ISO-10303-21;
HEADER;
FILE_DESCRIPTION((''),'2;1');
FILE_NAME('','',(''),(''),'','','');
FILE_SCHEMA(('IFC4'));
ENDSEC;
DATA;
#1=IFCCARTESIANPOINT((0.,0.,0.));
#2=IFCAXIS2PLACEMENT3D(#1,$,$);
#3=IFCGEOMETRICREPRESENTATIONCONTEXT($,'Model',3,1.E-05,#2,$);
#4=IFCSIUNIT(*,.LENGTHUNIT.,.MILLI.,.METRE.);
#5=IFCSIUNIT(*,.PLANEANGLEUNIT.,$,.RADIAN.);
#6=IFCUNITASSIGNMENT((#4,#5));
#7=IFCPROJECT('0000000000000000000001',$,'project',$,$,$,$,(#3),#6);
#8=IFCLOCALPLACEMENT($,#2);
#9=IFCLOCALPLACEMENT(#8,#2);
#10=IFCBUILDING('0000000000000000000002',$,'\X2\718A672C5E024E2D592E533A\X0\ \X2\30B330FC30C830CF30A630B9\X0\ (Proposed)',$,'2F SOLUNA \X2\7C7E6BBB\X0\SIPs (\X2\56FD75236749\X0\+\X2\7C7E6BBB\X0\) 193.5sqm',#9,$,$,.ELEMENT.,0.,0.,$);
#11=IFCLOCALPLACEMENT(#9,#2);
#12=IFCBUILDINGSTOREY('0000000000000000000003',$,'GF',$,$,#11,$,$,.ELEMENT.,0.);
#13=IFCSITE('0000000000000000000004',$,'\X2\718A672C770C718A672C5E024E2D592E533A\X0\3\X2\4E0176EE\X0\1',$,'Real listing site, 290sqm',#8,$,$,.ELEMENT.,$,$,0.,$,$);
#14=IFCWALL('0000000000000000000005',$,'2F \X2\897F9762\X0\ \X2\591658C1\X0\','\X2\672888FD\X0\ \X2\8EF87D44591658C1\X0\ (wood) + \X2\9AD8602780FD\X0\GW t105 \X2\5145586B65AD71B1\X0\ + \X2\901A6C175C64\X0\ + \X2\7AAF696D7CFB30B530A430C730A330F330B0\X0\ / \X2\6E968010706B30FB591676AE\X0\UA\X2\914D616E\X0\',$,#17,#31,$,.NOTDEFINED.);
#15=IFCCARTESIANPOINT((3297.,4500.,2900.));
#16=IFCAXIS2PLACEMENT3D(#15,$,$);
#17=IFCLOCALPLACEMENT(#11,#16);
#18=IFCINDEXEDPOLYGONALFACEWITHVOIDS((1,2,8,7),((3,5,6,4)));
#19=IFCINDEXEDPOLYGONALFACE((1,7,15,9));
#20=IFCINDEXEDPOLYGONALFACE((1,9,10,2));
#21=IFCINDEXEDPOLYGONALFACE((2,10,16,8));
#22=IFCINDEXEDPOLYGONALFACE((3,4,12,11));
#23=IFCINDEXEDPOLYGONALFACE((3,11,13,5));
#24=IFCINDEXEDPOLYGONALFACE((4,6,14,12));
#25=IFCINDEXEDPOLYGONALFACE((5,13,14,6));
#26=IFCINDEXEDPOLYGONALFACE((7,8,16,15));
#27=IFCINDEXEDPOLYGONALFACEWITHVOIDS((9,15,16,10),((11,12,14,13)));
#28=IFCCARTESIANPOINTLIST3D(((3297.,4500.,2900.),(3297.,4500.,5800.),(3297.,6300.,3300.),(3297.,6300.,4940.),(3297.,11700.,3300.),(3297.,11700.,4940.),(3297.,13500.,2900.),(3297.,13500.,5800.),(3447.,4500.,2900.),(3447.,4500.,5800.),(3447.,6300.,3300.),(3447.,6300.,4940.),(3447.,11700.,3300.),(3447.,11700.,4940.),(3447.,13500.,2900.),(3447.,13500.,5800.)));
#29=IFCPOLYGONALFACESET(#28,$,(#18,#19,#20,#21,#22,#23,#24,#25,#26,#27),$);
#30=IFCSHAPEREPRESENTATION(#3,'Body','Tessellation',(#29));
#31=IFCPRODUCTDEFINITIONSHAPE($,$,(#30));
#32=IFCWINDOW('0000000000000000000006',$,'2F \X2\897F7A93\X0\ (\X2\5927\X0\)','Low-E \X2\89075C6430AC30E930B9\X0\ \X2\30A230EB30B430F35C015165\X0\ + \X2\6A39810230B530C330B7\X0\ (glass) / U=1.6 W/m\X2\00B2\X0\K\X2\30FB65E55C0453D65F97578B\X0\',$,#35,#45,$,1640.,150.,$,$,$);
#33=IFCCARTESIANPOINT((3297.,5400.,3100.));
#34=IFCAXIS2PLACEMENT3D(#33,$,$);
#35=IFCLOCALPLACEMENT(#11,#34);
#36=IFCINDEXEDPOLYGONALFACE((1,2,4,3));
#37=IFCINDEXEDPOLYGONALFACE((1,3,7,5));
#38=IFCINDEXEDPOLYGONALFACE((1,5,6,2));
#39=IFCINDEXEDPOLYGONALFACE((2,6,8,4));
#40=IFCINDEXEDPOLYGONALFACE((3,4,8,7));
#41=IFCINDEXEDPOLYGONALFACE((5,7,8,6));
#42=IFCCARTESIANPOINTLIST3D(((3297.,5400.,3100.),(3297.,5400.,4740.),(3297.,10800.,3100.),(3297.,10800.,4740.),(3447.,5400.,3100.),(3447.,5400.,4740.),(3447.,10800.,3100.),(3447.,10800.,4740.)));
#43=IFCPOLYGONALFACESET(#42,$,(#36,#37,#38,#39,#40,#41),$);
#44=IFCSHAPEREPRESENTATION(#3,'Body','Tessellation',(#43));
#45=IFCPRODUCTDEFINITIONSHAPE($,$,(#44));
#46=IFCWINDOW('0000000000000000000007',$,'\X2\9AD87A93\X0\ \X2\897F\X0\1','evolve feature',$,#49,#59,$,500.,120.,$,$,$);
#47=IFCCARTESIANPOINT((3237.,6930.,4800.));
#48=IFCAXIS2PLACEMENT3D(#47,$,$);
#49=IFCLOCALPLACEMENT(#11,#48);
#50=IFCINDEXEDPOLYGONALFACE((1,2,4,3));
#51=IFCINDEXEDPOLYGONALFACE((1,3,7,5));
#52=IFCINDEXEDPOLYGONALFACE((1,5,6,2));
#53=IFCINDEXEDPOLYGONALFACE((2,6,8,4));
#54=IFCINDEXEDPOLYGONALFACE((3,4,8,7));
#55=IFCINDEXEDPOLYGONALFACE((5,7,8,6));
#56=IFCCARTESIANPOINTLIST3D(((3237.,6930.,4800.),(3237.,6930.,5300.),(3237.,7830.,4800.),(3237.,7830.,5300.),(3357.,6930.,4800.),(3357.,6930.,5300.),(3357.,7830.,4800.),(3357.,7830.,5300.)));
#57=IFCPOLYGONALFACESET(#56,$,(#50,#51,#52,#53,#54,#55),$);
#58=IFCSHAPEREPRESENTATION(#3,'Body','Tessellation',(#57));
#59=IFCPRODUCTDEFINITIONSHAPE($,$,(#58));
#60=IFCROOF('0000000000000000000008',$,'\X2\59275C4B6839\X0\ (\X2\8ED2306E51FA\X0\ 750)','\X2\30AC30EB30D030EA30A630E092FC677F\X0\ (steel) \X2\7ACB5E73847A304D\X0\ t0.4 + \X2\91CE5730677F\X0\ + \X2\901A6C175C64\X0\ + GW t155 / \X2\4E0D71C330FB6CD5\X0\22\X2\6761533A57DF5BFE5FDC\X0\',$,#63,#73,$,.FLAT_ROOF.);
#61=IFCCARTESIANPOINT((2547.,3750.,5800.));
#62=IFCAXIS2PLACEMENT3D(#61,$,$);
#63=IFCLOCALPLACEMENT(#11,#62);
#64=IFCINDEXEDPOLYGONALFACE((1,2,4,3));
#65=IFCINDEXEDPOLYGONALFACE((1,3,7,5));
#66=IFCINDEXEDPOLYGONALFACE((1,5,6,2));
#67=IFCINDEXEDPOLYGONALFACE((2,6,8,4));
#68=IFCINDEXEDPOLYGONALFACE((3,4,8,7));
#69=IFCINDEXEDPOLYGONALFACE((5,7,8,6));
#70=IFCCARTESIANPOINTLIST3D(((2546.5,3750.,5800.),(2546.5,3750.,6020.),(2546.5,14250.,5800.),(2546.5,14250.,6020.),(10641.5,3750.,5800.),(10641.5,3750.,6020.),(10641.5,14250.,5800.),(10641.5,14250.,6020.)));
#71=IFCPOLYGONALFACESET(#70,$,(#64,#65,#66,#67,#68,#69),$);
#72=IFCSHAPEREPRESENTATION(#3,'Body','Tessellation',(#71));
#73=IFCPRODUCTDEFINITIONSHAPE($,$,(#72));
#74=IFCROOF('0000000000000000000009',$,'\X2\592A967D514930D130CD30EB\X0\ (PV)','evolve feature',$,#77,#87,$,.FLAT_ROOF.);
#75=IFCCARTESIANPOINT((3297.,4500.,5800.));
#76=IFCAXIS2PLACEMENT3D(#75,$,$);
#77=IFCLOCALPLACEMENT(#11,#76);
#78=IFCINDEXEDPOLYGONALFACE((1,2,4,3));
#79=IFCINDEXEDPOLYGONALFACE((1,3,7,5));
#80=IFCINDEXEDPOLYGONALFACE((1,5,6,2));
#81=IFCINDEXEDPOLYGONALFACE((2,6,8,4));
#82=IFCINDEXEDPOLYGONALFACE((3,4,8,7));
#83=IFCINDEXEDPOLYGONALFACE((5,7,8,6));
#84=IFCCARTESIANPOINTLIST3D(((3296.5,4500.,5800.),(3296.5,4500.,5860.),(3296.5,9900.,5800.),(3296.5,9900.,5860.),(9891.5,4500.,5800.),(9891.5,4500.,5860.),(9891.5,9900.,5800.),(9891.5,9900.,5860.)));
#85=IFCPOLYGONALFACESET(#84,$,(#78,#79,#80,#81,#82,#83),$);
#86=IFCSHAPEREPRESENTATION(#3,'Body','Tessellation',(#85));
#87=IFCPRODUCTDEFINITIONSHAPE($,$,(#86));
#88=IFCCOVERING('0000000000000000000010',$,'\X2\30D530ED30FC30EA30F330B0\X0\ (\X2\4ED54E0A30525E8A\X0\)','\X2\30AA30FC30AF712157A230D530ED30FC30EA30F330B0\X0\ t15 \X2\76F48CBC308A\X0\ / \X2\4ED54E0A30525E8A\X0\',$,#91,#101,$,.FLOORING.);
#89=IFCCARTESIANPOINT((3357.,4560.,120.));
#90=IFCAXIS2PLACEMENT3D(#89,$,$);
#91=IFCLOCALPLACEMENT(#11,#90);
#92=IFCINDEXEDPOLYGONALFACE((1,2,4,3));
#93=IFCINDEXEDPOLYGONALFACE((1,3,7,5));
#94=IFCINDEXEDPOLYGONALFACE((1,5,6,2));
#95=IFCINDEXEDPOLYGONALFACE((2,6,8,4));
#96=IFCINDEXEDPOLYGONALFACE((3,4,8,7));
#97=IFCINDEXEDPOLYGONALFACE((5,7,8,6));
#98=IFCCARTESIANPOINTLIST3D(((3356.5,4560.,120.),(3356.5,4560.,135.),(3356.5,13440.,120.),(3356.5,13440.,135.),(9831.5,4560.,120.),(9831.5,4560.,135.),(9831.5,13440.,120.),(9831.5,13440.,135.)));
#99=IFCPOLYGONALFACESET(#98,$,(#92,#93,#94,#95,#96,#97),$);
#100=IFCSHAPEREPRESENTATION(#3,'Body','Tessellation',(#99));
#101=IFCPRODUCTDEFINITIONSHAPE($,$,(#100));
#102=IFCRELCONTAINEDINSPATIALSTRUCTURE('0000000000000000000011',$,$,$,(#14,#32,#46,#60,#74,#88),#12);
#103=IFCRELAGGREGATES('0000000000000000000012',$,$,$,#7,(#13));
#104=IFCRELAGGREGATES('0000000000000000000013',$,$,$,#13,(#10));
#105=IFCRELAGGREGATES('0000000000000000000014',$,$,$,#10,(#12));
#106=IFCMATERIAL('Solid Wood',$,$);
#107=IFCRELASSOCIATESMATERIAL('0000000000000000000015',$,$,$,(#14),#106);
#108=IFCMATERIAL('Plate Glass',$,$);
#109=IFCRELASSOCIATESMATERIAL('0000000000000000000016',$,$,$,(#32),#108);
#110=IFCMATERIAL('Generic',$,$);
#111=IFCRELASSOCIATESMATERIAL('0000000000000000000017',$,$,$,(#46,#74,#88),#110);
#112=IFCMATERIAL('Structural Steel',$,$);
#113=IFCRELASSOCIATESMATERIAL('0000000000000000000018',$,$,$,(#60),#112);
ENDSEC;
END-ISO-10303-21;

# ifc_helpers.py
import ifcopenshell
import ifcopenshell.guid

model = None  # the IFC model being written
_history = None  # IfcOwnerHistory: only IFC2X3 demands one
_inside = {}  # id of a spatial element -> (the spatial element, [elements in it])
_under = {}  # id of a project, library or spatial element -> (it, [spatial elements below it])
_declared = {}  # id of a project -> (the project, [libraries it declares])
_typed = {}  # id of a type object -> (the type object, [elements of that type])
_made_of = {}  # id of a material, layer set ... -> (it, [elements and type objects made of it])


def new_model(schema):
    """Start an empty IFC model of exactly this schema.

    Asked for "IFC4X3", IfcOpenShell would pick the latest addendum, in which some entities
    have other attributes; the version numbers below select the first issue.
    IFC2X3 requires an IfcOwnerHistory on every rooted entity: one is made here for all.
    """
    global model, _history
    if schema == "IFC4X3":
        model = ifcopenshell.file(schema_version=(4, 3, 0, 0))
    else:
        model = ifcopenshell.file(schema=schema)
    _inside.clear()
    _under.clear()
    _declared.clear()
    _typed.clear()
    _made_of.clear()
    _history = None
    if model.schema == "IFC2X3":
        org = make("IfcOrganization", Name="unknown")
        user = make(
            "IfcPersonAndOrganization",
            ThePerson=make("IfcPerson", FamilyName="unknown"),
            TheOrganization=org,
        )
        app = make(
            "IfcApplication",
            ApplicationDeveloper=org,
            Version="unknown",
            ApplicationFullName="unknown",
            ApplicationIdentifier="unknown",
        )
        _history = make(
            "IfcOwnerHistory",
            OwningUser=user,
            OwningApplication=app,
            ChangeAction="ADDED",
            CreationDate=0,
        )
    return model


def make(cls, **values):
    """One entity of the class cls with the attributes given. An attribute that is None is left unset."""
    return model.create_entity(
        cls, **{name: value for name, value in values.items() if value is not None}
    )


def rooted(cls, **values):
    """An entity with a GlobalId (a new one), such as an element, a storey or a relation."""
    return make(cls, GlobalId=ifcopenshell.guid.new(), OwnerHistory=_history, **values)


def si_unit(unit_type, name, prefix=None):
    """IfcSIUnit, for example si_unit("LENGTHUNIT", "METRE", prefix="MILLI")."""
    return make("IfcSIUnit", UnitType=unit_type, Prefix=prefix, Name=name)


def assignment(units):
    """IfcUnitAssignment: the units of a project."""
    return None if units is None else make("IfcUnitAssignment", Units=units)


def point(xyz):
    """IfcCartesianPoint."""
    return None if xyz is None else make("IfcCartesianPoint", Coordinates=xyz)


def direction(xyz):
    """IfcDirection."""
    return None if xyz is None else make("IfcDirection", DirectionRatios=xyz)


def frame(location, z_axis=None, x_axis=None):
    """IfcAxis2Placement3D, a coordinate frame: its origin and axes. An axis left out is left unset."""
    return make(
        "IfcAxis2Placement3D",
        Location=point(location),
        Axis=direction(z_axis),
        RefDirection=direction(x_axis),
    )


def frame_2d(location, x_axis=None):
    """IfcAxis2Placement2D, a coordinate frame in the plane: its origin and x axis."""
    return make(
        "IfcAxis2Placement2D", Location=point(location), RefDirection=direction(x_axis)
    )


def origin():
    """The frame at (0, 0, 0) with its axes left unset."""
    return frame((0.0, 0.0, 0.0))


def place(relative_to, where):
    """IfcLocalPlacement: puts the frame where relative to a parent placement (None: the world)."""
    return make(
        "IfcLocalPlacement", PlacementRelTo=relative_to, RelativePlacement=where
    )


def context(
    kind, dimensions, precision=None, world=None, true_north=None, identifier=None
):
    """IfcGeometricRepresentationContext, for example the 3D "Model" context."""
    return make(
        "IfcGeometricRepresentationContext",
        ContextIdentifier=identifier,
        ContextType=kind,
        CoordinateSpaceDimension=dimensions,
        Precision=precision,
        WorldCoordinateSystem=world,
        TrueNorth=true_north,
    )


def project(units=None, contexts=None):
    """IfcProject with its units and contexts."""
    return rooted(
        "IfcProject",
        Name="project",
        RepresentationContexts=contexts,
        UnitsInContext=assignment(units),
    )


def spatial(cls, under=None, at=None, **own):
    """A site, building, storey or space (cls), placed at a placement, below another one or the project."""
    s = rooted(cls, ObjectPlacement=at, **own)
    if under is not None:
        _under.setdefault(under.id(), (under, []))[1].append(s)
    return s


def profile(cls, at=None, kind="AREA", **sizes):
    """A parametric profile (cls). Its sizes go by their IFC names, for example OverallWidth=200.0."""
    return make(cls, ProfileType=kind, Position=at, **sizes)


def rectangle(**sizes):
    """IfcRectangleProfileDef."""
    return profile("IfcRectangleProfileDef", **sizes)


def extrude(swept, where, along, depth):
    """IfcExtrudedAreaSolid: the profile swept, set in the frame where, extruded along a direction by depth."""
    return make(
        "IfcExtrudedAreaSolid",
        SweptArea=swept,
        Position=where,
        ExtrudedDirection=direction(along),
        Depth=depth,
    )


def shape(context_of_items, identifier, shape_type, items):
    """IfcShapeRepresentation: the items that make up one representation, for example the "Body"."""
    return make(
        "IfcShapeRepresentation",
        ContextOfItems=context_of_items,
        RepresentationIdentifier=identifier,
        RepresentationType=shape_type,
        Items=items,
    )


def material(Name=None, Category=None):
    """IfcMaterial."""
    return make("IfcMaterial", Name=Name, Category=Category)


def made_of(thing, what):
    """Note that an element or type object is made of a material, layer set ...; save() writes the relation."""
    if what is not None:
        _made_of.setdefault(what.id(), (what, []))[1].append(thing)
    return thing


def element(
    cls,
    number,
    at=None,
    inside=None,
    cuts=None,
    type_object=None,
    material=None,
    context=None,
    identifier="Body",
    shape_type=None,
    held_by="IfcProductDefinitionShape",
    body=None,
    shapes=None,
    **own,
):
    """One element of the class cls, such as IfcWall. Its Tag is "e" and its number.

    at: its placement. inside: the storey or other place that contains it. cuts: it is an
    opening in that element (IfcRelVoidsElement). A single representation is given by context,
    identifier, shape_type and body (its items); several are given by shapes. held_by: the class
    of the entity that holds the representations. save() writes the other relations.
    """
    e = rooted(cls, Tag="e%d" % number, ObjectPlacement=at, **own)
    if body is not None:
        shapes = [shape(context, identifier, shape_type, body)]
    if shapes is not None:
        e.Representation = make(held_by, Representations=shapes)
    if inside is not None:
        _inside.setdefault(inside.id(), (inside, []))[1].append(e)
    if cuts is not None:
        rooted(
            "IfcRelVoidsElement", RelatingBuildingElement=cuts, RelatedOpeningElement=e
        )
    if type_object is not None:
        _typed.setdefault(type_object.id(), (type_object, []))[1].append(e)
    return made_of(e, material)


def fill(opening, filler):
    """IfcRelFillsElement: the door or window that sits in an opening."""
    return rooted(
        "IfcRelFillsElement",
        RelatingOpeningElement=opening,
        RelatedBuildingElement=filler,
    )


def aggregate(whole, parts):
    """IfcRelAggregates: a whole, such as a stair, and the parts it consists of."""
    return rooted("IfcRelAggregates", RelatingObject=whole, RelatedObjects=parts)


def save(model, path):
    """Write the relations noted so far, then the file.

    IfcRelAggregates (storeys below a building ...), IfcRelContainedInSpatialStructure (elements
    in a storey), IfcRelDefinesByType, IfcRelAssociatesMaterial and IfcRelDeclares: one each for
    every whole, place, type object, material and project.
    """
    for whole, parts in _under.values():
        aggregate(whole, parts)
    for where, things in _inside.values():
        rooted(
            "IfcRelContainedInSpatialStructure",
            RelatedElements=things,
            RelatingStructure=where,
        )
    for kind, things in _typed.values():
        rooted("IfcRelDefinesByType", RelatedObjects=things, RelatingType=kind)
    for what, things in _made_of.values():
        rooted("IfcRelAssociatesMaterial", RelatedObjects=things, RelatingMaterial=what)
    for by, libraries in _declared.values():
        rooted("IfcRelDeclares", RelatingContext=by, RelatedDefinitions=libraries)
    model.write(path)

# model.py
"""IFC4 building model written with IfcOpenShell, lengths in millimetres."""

from ifc_helpers import new_model, si_unit, frame, frame_2d, origin, place, context, project, spatial, rectangle, extrude, material, element, fill, save


model = new_model("IFC4")

# Units and contexts
model_context = context("Model", 3, precision=1e-05, world=origin())
ifc_project = project(units=[si_unit("LENGTHUNIT", "METRE", prefix="MILLI"), si_unit("PLANEANGLEUNIT", "RADIAN")], contexts=[model_context])

# Site, building, storey
site_placement = place(None, origin())
site = spatial("IfcSite", under=ifc_project, at=site_placement, Name="熊本県熊本市中央区3丁目1", ObjectType="Real listing site, 290sqm", CompositionType="ELEMENT", RefElevation=0.0)
building_placement = place(site_placement, origin())
building = spatial("IfcBuilding", under=site, at=building_placement, Name="熊本市中央区 コートハウス (Proposed)", ObjectType="2F SOLUNA 籾殻SIPs (国産杉+籾殻) 193.5sqm", CompositionType="ELEMENT", ElevationOfRefHeight=0.0, ElevationOfTerrain=0.0)
storey_placement = place(building_placement, origin())
storey = spatial("IfcBuildingStorey", under=building, at=storey_placement, Name="GF", CompositionType="ELEMENT", Elevation=0.0)

# Shared definitions
ifc_material_1 = material(Name="Solid Wood")

# Shared definitions
ifc_material_2 = material(Name="Plate Glass")
ifc_material_3 = material(Name="Generic")

# Wall, openings, windows
wall_1_placement = place(storey_placement, frame((3297.0, 4500.0, 2900.0)))
wall_1 = element("IfcWall", 1, at=wall_1_placement, inside=storey, material=ifc_material_1, Name="2F 西面 外壁", Description="木製 軸組外壁 (wood) + 高性能GW t105 充填断熱 + 通気層 + 窯業系サイディング / 準耐火・外皮UA配慮", PredefinedType="NOTDEFINED", context=model_context, shape_type="SweptSolid", body=[
    extrude(rectangle(XDim=150.0, YDim=9000.0, at=frame_2d((75.0, 4500.0))), frame((3297.0, 4500.0, 2900.0)), (0.0, 0.0, 1.0), 2900.0),
])
opening_1_placement = place(storey_placement, frame((3297.0, 5400.0, 3100.0)))
opening_1 = element("IfcOpeningElement", 2, at=opening_1_placement, cuts=wall_1, PredefinedType="NOTDEFINED", context=model_context, shape_type="SweptSolid", body=[
    extrude(rectangle(XDim=150.0, YDim=5400.0, at=frame_2d((75.0, 2700.0))), frame((3297.0, 5400.0, 3100.0)), (0.0, 0.0, 1.0), 1640.0),
])
opening_2_placement = place(storey_placement, frame((3237.0, 6930.0, 4800.0)))
opening_2 = element("IfcOpeningElement", 3, at=opening_2_placement, cuts=wall_1, PredefinedType="NOTDEFINED", context=model_context, shape_type="SweptSolid", body=[
    extrude(rectangle(XDim=120.0, YDim=900.0, at=frame_2d((60.0, 450.0))), frame((3237.0, 6930.0, 4800.0)), (0.0, 0.0, 1.0), 500.0),
])
window_1_placement = place(storey_placement, frame((3297.0, 5400.0, 3100.0)))
window_1 = element("IfcWindow", 4, at=window_1_placement, inside=storey, material=ifc_material_2, Name="2F 西窓 (大)", Description="Low-E 複層ガラス アルゴン封入 + 樹脂サッシ (glass) / U=1.6 W/m²K・日射取得型", OverallHeight=1640.0, OverallWidth=150.0, context=model_context, shape_type="SweptSolid", body=[
    extrude(rectangle(XDim=150.0, YDim=5400.0, at=frame_2d((75.0, 2700.0))), frame((3297.0, 5400.0, 3100.0)), (0.0, 0.0, 1.0), 1640.0),
])
fill(opening_1, window_1)
window_2_placement = place(storey_placement, frame((3237.0, 6930.0, 4800.0)))
window_2 = element("IfcWindow", 5, at=window_2_placement, inside=storey, material=ifc_material_3, Name="高窓 西1", Description="evolve feature", OverallHeight=500.0, OverallWidth=120.0, context=model_context, shape_type="SweptSolid", body=[
    extrude(rectangle(XDim=120.0, YDim=900.0, at=frame_2d((60.0, 450.0))), frame((3237.0, 6930.0, 4800.0)), (0.0, 0.0, 1.0), 500.0),
])
fill(opening_2, window_2)

# Roofs
ifc_material_4 = material(Name="Structural Steel")
roof_1_placement = place(storey_placement, frame((2547.0, 3750.0, 5800.0)))
element("IfcRoof", 6, at=roof_1_placement, inside=storey, material=ifc_material_4, Name="大屋根 (軒の出 750)", Description="ガルバリウム鋼板 (steel) 立平葺き t0.4 + 野地板 + 通気層 + GW t155 / 不燃・法22条区域対応", PredefinedType="FLAT_ROOF", context=model_context, shape_type="SweptSolid", body=[
    extrude(rectangle(XDim=8095.0, YDim=10500.0, at=frame_2d((4047.0, 5250.0))), frame((2547.0, 3750.0, 5800.0)), (0.0, 0.0, 1.0), 220.0),
])
roof_2_placement = place(storey_placement, frame((3297.0, 4500.0, 5800.0)))
element("IfcRoof", 7, at=roof_2_placement, inside=storey, material=ifc_material_3, Name="太陽光パネル (PV)", Description="evolve feature", PredefinedType="FLAT_ROOF", context=model_context, shape_type="SweptSolid", body=[
    extrude(rectangle(XDim=6595.0, YDim=5400.0, at=frame_2d((3297.0, 2700.0))), frame((3297.0, 4500.0, 5800.0)), (0.0, 0.0, 1.0), 60.0),
])

# Covering
covering_placement = place(storey_placement, frame((3357.0, 4560.0, 120.0)))
element("IfcCovering", 8, at=covering_placement, inside=storey, material=ifc_material_3, Name="フローリング (仕上げ床)", Description="オーク無垢フローリング t15 直貼り / 仕上げ床", PredefinedType="FLOORING", context=model_context, shape_type="SweptSolid", body=[
    extrude(rectangle(XDim=6475.0, YDim=8880.0, at=frame_2d((3237.0, 4440.0))), frame((3357.0, 4560.0, 120.0)), (0.0, 0.0, 1.0), 15.0),
])

save(model, "model.ifc")
